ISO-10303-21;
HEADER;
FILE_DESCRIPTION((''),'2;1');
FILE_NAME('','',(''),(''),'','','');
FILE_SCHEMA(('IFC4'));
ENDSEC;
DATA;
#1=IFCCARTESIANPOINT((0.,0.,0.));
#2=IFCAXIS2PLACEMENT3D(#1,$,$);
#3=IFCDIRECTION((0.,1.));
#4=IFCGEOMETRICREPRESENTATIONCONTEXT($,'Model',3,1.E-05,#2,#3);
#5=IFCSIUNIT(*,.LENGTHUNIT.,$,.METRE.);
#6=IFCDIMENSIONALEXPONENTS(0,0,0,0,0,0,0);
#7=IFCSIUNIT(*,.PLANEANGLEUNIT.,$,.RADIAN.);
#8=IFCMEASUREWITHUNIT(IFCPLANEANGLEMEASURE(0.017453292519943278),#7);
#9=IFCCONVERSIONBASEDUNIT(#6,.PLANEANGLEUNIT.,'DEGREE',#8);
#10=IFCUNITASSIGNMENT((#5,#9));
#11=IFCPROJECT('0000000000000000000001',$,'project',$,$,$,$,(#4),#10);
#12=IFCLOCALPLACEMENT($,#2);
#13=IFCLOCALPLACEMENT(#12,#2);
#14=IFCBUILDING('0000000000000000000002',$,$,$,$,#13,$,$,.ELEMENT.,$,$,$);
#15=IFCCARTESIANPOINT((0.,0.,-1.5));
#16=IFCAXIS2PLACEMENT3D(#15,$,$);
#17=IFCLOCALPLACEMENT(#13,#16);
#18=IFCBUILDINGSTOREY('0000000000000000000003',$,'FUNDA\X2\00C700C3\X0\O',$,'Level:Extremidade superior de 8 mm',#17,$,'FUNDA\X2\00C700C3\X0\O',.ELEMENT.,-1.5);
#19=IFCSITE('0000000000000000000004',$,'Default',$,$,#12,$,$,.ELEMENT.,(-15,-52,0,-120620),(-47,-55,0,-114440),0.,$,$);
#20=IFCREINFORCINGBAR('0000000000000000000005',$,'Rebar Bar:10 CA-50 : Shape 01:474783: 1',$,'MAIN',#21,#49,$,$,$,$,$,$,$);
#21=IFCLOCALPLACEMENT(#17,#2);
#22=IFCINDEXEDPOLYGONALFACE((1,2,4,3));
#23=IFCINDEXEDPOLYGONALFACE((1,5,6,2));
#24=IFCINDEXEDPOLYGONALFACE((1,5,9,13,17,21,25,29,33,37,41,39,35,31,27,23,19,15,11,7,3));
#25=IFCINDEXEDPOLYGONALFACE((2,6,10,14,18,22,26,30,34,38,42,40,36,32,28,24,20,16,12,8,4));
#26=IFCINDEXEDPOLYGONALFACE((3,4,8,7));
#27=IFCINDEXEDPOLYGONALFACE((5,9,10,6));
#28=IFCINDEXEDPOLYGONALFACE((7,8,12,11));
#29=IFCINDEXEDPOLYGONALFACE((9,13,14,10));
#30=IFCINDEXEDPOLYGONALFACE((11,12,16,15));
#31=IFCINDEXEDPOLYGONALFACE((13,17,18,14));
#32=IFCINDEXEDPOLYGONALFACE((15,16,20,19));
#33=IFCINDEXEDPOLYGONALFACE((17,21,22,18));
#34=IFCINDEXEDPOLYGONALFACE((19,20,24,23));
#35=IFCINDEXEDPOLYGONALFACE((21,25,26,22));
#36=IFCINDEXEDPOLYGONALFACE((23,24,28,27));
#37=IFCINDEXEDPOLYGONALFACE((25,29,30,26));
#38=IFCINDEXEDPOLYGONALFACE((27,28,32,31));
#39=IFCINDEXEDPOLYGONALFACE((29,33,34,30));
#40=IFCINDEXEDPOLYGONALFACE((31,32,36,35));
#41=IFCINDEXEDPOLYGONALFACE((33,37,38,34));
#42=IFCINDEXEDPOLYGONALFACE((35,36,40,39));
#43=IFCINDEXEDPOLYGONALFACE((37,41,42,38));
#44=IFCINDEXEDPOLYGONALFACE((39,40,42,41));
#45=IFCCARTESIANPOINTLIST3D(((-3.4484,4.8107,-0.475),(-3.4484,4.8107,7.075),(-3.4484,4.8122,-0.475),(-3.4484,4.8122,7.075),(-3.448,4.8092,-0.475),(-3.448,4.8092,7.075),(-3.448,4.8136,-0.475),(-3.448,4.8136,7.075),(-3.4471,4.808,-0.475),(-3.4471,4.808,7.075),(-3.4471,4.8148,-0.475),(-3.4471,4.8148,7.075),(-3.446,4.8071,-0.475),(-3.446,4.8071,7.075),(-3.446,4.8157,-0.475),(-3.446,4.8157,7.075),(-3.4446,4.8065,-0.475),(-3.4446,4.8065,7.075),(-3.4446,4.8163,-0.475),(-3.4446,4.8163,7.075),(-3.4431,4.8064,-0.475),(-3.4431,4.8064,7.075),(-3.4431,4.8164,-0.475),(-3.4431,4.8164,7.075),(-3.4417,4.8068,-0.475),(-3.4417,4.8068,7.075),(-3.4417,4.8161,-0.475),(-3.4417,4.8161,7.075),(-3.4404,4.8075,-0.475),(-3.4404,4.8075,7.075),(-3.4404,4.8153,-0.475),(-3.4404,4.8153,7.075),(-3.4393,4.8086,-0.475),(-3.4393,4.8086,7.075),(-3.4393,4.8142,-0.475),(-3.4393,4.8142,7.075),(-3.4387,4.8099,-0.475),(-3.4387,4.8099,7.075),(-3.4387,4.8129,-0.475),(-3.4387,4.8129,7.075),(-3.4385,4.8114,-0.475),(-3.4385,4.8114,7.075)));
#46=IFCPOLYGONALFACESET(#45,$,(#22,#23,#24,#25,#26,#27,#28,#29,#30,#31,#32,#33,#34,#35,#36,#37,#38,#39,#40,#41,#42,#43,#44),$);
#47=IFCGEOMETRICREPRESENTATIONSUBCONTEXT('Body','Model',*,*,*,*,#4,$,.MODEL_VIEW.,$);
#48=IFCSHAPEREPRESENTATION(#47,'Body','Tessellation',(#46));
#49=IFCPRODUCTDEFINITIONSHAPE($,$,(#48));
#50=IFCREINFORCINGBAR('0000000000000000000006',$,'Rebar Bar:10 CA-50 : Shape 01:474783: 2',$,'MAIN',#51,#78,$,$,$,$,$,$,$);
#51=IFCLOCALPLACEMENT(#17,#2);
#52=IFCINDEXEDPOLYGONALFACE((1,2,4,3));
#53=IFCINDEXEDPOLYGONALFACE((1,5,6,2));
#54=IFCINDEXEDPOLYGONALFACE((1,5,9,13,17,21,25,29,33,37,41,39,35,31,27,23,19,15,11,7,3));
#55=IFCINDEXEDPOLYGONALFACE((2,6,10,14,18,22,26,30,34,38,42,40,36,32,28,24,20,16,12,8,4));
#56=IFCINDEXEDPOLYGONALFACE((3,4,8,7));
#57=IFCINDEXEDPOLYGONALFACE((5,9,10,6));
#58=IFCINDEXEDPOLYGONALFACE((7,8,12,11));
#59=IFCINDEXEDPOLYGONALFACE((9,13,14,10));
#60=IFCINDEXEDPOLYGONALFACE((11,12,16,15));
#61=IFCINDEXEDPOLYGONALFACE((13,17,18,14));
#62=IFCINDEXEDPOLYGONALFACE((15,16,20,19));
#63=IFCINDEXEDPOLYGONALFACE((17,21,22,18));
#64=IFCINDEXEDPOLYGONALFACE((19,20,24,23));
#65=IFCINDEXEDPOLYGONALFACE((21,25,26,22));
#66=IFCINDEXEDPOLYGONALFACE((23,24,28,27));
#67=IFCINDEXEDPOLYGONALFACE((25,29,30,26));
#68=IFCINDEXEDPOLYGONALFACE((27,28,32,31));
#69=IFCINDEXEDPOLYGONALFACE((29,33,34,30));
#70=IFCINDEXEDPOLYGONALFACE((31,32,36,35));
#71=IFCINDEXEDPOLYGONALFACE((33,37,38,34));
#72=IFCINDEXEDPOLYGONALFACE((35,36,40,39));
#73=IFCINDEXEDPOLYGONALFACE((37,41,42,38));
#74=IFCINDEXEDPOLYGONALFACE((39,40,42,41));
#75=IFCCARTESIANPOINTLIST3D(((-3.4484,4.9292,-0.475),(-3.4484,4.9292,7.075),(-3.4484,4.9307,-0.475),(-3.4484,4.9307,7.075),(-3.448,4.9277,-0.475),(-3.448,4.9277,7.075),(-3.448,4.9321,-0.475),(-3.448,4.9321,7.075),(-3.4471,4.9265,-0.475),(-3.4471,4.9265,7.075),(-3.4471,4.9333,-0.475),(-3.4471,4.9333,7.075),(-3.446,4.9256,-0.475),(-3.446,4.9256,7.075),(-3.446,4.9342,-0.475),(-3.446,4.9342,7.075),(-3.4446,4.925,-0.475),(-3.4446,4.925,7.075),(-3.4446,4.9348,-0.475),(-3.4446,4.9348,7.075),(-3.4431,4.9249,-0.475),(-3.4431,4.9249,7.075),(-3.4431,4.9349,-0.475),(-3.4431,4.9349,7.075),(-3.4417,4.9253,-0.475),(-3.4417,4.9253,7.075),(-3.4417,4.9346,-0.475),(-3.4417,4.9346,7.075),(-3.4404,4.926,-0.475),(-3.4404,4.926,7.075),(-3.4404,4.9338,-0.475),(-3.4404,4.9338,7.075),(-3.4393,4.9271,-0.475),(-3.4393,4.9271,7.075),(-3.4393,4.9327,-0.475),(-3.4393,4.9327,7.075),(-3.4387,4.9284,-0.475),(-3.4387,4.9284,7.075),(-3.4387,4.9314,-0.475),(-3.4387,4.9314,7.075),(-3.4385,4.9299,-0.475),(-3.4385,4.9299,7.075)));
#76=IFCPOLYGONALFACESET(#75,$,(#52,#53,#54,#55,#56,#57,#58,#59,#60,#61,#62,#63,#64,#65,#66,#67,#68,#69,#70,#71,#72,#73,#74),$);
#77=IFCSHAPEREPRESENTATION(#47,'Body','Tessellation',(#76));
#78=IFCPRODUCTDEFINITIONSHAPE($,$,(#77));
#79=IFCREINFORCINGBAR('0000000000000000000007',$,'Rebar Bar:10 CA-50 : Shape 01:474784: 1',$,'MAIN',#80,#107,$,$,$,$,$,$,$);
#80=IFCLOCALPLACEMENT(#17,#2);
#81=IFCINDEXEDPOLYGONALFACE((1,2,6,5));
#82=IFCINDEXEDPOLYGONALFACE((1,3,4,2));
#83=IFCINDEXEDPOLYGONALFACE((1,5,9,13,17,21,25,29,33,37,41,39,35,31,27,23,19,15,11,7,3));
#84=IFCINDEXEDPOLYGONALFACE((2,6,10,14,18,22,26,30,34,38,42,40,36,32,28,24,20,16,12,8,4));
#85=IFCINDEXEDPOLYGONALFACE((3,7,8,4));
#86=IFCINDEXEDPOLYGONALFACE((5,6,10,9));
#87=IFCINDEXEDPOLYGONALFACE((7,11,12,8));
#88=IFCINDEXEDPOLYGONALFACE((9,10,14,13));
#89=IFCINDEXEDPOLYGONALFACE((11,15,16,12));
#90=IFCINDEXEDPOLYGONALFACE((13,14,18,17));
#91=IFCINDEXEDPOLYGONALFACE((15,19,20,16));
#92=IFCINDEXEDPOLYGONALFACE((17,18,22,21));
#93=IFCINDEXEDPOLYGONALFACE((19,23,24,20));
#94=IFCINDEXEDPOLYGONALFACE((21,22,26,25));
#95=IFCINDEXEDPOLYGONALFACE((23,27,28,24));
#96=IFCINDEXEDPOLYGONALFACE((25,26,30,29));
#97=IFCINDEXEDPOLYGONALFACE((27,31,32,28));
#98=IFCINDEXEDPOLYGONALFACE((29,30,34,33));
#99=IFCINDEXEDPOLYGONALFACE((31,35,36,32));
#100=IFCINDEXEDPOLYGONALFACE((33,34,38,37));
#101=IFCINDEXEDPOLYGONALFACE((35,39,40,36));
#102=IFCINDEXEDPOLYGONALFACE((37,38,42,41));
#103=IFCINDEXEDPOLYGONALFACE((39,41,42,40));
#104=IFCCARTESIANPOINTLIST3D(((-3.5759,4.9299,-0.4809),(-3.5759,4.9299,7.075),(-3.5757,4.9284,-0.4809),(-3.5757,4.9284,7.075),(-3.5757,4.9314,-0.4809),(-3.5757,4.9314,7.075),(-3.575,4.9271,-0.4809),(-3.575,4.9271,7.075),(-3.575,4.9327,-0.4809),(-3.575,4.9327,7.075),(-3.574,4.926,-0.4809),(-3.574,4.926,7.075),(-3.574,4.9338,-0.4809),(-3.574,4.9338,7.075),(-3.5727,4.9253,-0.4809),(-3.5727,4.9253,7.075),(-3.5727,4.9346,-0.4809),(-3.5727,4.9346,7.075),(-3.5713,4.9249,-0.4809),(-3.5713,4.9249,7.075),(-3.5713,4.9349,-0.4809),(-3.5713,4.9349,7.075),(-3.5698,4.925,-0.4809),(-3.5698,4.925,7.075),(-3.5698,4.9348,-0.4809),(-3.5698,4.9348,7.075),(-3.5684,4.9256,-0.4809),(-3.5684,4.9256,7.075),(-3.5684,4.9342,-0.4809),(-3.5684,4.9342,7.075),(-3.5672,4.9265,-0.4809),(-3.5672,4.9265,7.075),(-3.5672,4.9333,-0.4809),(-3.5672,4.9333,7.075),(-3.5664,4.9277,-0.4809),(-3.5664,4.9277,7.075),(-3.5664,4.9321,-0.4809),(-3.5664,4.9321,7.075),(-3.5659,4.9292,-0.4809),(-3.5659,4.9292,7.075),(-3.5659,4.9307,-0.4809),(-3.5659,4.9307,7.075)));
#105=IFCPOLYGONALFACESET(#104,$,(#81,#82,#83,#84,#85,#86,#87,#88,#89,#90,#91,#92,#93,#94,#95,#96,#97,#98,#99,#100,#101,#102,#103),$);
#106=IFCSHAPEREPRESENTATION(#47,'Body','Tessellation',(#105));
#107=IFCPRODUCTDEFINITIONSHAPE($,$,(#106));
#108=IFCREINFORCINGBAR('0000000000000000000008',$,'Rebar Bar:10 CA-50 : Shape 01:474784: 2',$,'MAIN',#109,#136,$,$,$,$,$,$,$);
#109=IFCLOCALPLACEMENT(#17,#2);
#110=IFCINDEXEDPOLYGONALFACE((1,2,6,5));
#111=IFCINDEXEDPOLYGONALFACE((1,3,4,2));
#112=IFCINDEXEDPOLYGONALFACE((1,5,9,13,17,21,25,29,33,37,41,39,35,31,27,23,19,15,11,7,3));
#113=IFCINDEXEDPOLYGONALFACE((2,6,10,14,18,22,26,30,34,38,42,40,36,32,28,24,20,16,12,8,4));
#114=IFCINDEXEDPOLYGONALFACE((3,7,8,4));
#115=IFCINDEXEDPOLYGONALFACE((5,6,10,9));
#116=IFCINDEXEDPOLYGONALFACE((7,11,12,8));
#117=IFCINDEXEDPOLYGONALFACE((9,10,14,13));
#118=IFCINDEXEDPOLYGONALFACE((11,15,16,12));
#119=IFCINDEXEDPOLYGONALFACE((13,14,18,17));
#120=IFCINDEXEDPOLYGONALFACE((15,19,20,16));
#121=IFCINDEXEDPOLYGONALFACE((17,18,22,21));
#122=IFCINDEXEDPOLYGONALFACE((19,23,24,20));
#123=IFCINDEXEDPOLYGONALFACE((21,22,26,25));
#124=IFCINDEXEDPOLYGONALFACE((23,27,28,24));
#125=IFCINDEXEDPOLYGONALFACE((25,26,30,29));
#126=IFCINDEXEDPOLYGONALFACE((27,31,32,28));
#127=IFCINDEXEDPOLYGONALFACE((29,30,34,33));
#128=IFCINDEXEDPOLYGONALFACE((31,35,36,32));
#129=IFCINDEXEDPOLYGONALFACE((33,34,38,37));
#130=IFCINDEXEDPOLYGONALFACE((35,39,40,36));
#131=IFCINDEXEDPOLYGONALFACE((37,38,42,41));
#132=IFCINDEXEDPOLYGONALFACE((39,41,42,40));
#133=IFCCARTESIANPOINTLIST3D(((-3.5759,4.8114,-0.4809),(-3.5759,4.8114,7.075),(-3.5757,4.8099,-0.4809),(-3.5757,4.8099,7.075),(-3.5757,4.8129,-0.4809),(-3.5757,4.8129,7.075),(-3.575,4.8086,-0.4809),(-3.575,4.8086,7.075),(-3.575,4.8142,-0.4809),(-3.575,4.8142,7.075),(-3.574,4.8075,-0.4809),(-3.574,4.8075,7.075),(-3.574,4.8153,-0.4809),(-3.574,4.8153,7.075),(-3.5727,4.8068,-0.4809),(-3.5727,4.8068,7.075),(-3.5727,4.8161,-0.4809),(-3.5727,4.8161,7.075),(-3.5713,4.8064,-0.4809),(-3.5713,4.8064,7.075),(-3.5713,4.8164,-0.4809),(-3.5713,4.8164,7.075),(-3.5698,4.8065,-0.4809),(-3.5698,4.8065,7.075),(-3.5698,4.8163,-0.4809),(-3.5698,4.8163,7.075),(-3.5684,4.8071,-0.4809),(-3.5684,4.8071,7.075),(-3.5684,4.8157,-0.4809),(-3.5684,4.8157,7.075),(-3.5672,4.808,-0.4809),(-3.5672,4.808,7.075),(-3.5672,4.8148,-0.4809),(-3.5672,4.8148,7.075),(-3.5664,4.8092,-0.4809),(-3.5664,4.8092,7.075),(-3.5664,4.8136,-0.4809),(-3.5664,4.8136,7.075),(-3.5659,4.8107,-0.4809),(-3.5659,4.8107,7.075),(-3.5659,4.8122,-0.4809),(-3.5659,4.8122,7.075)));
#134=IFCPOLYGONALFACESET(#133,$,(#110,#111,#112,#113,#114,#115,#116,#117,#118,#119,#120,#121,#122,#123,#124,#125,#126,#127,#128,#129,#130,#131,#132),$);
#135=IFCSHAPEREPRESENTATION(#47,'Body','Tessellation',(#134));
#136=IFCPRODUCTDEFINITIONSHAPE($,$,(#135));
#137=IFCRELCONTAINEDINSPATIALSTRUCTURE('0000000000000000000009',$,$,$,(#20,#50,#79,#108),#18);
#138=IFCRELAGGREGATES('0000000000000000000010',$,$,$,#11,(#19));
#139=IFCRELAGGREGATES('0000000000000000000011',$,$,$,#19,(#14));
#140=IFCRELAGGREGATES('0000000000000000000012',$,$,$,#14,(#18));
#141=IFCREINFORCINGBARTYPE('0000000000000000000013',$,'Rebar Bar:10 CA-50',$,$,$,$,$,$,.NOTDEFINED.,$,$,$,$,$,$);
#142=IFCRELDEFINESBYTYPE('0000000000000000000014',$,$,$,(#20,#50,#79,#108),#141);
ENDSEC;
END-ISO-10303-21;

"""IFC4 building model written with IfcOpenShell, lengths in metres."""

from ifc_helpers import new_model, entity, si_unit, converted_unit, direction, frame, origin, place, context, subcontext, project, spatial, type_object, element, save


model = new_model("IFC4")

# Units and contexts
model_context = context("Model", 3, precision=1e-05, world=origin(), true_north=direction((0.0, 1.0)))
body_context = subcontext(model_context, "Body", "Model", "MODEL_VIEW")
ifc_project = project(units=[si_unit("LENGTHUNIT", "METRE"), converted_unit("PLANEANGLEUNIT", "DEGREE", entity("IfcPlaneAngleMeasure", 0.017453292519943278), si_unit("PLANEANGLEUNIT", "RADIAN"), dimensions=[0, 0, 0, 0, 0, 0, 0])], contexts=[model_context])

# Site, building, storey
site_placement = place(None, origin())
site = spatial("IfcSite", under=ifc_project, at=site_placement, Name="Default", CompositionType="ELEMENT", RefLatitude=(-15, -52, 0, -120620), RefLongitude=(-47, -55, 0, -114440), RefElevation=0.0)
building_placement = place(site_placement, origin())
building = spatial("IfcBuilding", under=site, at=building_placement, CompositionType="ELEMENT")
storey_placement = place(building_placement, frame((0.0, 0.0, -1.5)))
storey = spatial("IfcBuildingStorey", under=building, at=storey_placement, Name="FUNDAÇÃO", ObjectType="Level:Extremidade superior de 8 mm", LongName="FUNDAÇÃO", CompositionType="ELEMENT", Elevation=-1.5)

# Reinforcing bars
reinforcing_bar_type_1 = type_object("IfcReinforcingBarType", Name="Rebar Bar:10 CA-50", PredefinedType="NOTDEFINED")
reinforcing_bar_1_placement = place(storey_placement, origin())
element("IfcReinforcingBar", 1, at=reinforcing_bar_1_placement, inside=storey, type_object=reinforcing_bar_type_1, Name="Rebar Bar:10 CA-50 : Shape 01:474783: 1", ObjectType="MAIN", context=body_context, shape_type="AdvancedSweptSolid", body=[
    entity("IfcSweptDiskSolid", entity("IfcIndexedPolyCurve", entity("IfcCartesianPointList3D", [[-3.4435, 4.8114, -0.475], [-3.4435, 4.8114, 7.075]]), None, False), 0.005, None, 0.0, 1.0),
])
reinforcing_bar_2_placement = place(storey_placement, origin())
element("IfcReinforcingBar", 2, at=reinforcing_bar_2_placement, inside=storey, type_object=reinforcing_bar_type_1, Name="Rebar Bar:10 CA-50 : Shape 01:474783: 2", ObjectType="MAIN", context=body_context, shape_type="AdvancedSweptSolid", body=[
    entity("IfcSweptDiskSolid", entity("IfcIndexedPolyCurve", entity("IfcCartesianPointList3D", [[-3.4435, 4.9299, -0.475], [-3.4435, 4.9299, 7.075]]), None, False), 0.005, None, 0.0, 1.0),
])
reinforcing_bar_3_placement = place(storey_placement, origin())
element("IfcReinforcingBar", 3, at=reinforcing_bar_3_placement, inside=storey, type_object=reinforcing_bar_type_1, Name="Rebar Bar:10 CA-50 : Shape 01:474784: 1", ObjectType="MAIN", context=body_context, shape_type="AdvancedSweptSolid", body=[
    entity("IfcSweptDiskSolid", entity("IfcIndexedPolyCurve", entity("IfcCartesianPointList3D", [[-3.5709, 4.9299, 7.075], [-3.5709, 4.9299, -0.4809]]), None, False), 0.005, None, 0.0, 1.0),
])
reinforcing_bar_4_placement = place(storey_placement, origin())
element("IfcReinforcingBar", 4, at=reinforcing_bar_4_placement, inside=storey, type_object=reinforcing_bar_type_1, Name="Rebar Bar:10 CA-50 : Shape 01:474784: 2", ObjectType="MAIN", context=body_context, shape_type="AdvancedSweptSolid", body=[
    entity("IfcSweptDiskSolid", entity("IfcIndexedPolyCurve", entity("IfcCartesianPointList3D", [[-3.5709, 4.8114, 7.075], [-3.5709, 4.8114, -0.4809]]), None, False), 0.005, None, 0.0, 1.0),
])

save(model, "model.ifc")
